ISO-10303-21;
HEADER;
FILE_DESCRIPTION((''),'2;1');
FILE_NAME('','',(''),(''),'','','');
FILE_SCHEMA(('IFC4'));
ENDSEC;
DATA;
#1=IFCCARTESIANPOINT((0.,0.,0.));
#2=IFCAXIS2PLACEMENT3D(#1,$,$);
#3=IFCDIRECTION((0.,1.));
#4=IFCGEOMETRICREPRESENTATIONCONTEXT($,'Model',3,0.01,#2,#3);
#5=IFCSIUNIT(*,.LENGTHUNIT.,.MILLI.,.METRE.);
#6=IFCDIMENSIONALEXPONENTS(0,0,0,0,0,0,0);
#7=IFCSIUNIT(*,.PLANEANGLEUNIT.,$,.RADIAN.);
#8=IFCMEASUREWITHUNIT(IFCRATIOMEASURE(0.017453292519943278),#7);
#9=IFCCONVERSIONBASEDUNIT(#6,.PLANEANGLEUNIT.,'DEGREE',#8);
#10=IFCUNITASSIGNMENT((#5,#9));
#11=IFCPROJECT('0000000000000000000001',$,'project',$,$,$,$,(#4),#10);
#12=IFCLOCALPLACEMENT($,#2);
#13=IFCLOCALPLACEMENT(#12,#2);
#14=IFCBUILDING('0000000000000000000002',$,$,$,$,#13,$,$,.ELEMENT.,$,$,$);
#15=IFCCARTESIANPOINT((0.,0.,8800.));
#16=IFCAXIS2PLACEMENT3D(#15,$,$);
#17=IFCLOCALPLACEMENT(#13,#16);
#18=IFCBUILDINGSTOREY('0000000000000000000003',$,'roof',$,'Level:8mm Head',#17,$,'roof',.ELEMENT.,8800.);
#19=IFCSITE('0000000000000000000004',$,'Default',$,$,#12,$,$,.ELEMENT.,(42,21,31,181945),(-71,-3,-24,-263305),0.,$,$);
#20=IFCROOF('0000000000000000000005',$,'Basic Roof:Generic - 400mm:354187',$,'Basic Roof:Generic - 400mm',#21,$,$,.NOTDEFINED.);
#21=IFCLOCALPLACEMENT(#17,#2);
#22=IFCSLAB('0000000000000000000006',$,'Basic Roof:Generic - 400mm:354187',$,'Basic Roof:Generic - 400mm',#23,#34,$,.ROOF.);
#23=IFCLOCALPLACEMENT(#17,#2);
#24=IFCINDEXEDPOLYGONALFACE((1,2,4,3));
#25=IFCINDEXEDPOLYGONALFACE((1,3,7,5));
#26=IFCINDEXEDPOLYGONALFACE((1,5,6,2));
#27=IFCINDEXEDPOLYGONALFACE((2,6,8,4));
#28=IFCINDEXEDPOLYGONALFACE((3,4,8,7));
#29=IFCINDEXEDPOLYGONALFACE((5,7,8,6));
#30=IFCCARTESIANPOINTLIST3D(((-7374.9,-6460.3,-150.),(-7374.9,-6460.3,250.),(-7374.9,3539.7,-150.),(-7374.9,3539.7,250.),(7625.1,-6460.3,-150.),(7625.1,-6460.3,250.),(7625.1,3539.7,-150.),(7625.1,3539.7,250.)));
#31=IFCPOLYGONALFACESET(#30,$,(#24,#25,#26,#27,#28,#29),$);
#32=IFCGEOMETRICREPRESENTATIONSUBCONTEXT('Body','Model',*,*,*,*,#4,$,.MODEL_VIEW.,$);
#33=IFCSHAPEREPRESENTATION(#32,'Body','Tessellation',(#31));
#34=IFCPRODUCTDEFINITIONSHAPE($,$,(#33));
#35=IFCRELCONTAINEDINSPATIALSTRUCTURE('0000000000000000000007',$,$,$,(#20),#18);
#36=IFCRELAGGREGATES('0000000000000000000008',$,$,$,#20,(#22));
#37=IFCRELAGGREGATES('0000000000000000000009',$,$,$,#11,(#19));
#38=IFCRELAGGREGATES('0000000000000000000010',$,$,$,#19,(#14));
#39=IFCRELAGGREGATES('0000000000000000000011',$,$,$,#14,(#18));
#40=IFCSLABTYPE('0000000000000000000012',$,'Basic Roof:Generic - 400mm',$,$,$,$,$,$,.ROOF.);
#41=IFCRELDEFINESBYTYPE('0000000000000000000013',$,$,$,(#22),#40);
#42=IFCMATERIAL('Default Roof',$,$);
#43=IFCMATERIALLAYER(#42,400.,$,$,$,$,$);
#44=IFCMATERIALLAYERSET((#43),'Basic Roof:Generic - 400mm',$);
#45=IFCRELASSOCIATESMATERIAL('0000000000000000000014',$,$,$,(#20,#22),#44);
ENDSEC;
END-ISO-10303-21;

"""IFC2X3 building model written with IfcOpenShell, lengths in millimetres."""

from ifc_helpers import new_model, entity, si_unit, converted_unit, direction, frame, origin, origin_2d_with_axis, place, context, subcontext, project, spatial, rectangle, extrude, material, layer, layer_set, type_object, element, aggregate, save


model = new_model("IFC2X3")

# Units and contexts
model_context = context("Model", 3, precision=0.01, world=origin(), true_north=direction((0.0, 1.0)))
body_context = subcontext(model_context, "Body", "Model", "MODEL_VIEW")
ifc_project = project(units=[si_unit("LENGTHUNIT", "METRE", prefix="MILLI"), converted_unit("PLANEANGLEUNIT", "DEGREE", entity("IfcRatioMeasure", 0.017453292519943278), si_unit("PLANEANGLEUNIT", "RADIAN"), dimensions=[0, 0, 0, 0, 0, 0, 0])], contexts=[model_context])

# Site, building, storey
site_placement = place(None, origin())
site = spatial("IfcSite", under=ifc_project, at=site_placement, Name="Default", CompositionType="ELEMENT", RefLatitude=(42, 21, 31, 181945), RefLongitude=(-71, -3, -24, -263305), RefElevation=0.0)
building_placement = place(site_placement, origin())
building = spatial("IfcBuilding", under=site, at=building_placement, CompositionType="ELEMENT")
storey_placement = place(building_placement, frame((0.0, 0.0, 8800.0)))
storey = spatial("IfcBuildingStorey", under=building, at=storey_placement, Name="roof", ObjectType="Level:8mm Head", LongName="roof", CompositionType="ELEMENT", Elevation=8800.0)

# Roof, slab
ifc_material = material(Name="Default Roof")
ifc_layer = layer(ifc_material, 400.0)
ifc_layer_set = layer_set([ifc_layer], Name="Basic Roof:Generic - 400mm")
roof_placement = place(storey_placement, frame((-7374.9, -6460.3, -150.0)))
roof = element("IfcRoof", 1, at=roof_placement, inside=storey, material=ifc_layer_set, Name="Basic Roof:Generic - 400mm:354187", ObjectType="Basic Roof:Generic - 400mm", ShapeType="NOTDEFINED")
slab_type = type_object("IfcSlabType", Name="Basic Roof:Generic - 400mm", PredefinedType="ROOF")
slab_placement = place(roof_placement, origin())
slab = element("IfcSlab", 2, at=slab_placement, type_object=slab_type, material=ifc_layer_set, Name="Basic Roof:Generic - 400mm:354187", ObjectType="Basic Roof:Generic - 400mm", PredefinedType="ROOF", context=body_context, shape_type="SweptSolid", body=[
    extrude(rectangle(XDim=15000.0, YDim=10000.0, at=origin_2d_with_axis()), frame((7500.0, 5000.0, 0.0)), (0.0, 0.0, 1.0), 400.0),
])
aggregate(roof, [slab])

save(model, "model.ifc")
